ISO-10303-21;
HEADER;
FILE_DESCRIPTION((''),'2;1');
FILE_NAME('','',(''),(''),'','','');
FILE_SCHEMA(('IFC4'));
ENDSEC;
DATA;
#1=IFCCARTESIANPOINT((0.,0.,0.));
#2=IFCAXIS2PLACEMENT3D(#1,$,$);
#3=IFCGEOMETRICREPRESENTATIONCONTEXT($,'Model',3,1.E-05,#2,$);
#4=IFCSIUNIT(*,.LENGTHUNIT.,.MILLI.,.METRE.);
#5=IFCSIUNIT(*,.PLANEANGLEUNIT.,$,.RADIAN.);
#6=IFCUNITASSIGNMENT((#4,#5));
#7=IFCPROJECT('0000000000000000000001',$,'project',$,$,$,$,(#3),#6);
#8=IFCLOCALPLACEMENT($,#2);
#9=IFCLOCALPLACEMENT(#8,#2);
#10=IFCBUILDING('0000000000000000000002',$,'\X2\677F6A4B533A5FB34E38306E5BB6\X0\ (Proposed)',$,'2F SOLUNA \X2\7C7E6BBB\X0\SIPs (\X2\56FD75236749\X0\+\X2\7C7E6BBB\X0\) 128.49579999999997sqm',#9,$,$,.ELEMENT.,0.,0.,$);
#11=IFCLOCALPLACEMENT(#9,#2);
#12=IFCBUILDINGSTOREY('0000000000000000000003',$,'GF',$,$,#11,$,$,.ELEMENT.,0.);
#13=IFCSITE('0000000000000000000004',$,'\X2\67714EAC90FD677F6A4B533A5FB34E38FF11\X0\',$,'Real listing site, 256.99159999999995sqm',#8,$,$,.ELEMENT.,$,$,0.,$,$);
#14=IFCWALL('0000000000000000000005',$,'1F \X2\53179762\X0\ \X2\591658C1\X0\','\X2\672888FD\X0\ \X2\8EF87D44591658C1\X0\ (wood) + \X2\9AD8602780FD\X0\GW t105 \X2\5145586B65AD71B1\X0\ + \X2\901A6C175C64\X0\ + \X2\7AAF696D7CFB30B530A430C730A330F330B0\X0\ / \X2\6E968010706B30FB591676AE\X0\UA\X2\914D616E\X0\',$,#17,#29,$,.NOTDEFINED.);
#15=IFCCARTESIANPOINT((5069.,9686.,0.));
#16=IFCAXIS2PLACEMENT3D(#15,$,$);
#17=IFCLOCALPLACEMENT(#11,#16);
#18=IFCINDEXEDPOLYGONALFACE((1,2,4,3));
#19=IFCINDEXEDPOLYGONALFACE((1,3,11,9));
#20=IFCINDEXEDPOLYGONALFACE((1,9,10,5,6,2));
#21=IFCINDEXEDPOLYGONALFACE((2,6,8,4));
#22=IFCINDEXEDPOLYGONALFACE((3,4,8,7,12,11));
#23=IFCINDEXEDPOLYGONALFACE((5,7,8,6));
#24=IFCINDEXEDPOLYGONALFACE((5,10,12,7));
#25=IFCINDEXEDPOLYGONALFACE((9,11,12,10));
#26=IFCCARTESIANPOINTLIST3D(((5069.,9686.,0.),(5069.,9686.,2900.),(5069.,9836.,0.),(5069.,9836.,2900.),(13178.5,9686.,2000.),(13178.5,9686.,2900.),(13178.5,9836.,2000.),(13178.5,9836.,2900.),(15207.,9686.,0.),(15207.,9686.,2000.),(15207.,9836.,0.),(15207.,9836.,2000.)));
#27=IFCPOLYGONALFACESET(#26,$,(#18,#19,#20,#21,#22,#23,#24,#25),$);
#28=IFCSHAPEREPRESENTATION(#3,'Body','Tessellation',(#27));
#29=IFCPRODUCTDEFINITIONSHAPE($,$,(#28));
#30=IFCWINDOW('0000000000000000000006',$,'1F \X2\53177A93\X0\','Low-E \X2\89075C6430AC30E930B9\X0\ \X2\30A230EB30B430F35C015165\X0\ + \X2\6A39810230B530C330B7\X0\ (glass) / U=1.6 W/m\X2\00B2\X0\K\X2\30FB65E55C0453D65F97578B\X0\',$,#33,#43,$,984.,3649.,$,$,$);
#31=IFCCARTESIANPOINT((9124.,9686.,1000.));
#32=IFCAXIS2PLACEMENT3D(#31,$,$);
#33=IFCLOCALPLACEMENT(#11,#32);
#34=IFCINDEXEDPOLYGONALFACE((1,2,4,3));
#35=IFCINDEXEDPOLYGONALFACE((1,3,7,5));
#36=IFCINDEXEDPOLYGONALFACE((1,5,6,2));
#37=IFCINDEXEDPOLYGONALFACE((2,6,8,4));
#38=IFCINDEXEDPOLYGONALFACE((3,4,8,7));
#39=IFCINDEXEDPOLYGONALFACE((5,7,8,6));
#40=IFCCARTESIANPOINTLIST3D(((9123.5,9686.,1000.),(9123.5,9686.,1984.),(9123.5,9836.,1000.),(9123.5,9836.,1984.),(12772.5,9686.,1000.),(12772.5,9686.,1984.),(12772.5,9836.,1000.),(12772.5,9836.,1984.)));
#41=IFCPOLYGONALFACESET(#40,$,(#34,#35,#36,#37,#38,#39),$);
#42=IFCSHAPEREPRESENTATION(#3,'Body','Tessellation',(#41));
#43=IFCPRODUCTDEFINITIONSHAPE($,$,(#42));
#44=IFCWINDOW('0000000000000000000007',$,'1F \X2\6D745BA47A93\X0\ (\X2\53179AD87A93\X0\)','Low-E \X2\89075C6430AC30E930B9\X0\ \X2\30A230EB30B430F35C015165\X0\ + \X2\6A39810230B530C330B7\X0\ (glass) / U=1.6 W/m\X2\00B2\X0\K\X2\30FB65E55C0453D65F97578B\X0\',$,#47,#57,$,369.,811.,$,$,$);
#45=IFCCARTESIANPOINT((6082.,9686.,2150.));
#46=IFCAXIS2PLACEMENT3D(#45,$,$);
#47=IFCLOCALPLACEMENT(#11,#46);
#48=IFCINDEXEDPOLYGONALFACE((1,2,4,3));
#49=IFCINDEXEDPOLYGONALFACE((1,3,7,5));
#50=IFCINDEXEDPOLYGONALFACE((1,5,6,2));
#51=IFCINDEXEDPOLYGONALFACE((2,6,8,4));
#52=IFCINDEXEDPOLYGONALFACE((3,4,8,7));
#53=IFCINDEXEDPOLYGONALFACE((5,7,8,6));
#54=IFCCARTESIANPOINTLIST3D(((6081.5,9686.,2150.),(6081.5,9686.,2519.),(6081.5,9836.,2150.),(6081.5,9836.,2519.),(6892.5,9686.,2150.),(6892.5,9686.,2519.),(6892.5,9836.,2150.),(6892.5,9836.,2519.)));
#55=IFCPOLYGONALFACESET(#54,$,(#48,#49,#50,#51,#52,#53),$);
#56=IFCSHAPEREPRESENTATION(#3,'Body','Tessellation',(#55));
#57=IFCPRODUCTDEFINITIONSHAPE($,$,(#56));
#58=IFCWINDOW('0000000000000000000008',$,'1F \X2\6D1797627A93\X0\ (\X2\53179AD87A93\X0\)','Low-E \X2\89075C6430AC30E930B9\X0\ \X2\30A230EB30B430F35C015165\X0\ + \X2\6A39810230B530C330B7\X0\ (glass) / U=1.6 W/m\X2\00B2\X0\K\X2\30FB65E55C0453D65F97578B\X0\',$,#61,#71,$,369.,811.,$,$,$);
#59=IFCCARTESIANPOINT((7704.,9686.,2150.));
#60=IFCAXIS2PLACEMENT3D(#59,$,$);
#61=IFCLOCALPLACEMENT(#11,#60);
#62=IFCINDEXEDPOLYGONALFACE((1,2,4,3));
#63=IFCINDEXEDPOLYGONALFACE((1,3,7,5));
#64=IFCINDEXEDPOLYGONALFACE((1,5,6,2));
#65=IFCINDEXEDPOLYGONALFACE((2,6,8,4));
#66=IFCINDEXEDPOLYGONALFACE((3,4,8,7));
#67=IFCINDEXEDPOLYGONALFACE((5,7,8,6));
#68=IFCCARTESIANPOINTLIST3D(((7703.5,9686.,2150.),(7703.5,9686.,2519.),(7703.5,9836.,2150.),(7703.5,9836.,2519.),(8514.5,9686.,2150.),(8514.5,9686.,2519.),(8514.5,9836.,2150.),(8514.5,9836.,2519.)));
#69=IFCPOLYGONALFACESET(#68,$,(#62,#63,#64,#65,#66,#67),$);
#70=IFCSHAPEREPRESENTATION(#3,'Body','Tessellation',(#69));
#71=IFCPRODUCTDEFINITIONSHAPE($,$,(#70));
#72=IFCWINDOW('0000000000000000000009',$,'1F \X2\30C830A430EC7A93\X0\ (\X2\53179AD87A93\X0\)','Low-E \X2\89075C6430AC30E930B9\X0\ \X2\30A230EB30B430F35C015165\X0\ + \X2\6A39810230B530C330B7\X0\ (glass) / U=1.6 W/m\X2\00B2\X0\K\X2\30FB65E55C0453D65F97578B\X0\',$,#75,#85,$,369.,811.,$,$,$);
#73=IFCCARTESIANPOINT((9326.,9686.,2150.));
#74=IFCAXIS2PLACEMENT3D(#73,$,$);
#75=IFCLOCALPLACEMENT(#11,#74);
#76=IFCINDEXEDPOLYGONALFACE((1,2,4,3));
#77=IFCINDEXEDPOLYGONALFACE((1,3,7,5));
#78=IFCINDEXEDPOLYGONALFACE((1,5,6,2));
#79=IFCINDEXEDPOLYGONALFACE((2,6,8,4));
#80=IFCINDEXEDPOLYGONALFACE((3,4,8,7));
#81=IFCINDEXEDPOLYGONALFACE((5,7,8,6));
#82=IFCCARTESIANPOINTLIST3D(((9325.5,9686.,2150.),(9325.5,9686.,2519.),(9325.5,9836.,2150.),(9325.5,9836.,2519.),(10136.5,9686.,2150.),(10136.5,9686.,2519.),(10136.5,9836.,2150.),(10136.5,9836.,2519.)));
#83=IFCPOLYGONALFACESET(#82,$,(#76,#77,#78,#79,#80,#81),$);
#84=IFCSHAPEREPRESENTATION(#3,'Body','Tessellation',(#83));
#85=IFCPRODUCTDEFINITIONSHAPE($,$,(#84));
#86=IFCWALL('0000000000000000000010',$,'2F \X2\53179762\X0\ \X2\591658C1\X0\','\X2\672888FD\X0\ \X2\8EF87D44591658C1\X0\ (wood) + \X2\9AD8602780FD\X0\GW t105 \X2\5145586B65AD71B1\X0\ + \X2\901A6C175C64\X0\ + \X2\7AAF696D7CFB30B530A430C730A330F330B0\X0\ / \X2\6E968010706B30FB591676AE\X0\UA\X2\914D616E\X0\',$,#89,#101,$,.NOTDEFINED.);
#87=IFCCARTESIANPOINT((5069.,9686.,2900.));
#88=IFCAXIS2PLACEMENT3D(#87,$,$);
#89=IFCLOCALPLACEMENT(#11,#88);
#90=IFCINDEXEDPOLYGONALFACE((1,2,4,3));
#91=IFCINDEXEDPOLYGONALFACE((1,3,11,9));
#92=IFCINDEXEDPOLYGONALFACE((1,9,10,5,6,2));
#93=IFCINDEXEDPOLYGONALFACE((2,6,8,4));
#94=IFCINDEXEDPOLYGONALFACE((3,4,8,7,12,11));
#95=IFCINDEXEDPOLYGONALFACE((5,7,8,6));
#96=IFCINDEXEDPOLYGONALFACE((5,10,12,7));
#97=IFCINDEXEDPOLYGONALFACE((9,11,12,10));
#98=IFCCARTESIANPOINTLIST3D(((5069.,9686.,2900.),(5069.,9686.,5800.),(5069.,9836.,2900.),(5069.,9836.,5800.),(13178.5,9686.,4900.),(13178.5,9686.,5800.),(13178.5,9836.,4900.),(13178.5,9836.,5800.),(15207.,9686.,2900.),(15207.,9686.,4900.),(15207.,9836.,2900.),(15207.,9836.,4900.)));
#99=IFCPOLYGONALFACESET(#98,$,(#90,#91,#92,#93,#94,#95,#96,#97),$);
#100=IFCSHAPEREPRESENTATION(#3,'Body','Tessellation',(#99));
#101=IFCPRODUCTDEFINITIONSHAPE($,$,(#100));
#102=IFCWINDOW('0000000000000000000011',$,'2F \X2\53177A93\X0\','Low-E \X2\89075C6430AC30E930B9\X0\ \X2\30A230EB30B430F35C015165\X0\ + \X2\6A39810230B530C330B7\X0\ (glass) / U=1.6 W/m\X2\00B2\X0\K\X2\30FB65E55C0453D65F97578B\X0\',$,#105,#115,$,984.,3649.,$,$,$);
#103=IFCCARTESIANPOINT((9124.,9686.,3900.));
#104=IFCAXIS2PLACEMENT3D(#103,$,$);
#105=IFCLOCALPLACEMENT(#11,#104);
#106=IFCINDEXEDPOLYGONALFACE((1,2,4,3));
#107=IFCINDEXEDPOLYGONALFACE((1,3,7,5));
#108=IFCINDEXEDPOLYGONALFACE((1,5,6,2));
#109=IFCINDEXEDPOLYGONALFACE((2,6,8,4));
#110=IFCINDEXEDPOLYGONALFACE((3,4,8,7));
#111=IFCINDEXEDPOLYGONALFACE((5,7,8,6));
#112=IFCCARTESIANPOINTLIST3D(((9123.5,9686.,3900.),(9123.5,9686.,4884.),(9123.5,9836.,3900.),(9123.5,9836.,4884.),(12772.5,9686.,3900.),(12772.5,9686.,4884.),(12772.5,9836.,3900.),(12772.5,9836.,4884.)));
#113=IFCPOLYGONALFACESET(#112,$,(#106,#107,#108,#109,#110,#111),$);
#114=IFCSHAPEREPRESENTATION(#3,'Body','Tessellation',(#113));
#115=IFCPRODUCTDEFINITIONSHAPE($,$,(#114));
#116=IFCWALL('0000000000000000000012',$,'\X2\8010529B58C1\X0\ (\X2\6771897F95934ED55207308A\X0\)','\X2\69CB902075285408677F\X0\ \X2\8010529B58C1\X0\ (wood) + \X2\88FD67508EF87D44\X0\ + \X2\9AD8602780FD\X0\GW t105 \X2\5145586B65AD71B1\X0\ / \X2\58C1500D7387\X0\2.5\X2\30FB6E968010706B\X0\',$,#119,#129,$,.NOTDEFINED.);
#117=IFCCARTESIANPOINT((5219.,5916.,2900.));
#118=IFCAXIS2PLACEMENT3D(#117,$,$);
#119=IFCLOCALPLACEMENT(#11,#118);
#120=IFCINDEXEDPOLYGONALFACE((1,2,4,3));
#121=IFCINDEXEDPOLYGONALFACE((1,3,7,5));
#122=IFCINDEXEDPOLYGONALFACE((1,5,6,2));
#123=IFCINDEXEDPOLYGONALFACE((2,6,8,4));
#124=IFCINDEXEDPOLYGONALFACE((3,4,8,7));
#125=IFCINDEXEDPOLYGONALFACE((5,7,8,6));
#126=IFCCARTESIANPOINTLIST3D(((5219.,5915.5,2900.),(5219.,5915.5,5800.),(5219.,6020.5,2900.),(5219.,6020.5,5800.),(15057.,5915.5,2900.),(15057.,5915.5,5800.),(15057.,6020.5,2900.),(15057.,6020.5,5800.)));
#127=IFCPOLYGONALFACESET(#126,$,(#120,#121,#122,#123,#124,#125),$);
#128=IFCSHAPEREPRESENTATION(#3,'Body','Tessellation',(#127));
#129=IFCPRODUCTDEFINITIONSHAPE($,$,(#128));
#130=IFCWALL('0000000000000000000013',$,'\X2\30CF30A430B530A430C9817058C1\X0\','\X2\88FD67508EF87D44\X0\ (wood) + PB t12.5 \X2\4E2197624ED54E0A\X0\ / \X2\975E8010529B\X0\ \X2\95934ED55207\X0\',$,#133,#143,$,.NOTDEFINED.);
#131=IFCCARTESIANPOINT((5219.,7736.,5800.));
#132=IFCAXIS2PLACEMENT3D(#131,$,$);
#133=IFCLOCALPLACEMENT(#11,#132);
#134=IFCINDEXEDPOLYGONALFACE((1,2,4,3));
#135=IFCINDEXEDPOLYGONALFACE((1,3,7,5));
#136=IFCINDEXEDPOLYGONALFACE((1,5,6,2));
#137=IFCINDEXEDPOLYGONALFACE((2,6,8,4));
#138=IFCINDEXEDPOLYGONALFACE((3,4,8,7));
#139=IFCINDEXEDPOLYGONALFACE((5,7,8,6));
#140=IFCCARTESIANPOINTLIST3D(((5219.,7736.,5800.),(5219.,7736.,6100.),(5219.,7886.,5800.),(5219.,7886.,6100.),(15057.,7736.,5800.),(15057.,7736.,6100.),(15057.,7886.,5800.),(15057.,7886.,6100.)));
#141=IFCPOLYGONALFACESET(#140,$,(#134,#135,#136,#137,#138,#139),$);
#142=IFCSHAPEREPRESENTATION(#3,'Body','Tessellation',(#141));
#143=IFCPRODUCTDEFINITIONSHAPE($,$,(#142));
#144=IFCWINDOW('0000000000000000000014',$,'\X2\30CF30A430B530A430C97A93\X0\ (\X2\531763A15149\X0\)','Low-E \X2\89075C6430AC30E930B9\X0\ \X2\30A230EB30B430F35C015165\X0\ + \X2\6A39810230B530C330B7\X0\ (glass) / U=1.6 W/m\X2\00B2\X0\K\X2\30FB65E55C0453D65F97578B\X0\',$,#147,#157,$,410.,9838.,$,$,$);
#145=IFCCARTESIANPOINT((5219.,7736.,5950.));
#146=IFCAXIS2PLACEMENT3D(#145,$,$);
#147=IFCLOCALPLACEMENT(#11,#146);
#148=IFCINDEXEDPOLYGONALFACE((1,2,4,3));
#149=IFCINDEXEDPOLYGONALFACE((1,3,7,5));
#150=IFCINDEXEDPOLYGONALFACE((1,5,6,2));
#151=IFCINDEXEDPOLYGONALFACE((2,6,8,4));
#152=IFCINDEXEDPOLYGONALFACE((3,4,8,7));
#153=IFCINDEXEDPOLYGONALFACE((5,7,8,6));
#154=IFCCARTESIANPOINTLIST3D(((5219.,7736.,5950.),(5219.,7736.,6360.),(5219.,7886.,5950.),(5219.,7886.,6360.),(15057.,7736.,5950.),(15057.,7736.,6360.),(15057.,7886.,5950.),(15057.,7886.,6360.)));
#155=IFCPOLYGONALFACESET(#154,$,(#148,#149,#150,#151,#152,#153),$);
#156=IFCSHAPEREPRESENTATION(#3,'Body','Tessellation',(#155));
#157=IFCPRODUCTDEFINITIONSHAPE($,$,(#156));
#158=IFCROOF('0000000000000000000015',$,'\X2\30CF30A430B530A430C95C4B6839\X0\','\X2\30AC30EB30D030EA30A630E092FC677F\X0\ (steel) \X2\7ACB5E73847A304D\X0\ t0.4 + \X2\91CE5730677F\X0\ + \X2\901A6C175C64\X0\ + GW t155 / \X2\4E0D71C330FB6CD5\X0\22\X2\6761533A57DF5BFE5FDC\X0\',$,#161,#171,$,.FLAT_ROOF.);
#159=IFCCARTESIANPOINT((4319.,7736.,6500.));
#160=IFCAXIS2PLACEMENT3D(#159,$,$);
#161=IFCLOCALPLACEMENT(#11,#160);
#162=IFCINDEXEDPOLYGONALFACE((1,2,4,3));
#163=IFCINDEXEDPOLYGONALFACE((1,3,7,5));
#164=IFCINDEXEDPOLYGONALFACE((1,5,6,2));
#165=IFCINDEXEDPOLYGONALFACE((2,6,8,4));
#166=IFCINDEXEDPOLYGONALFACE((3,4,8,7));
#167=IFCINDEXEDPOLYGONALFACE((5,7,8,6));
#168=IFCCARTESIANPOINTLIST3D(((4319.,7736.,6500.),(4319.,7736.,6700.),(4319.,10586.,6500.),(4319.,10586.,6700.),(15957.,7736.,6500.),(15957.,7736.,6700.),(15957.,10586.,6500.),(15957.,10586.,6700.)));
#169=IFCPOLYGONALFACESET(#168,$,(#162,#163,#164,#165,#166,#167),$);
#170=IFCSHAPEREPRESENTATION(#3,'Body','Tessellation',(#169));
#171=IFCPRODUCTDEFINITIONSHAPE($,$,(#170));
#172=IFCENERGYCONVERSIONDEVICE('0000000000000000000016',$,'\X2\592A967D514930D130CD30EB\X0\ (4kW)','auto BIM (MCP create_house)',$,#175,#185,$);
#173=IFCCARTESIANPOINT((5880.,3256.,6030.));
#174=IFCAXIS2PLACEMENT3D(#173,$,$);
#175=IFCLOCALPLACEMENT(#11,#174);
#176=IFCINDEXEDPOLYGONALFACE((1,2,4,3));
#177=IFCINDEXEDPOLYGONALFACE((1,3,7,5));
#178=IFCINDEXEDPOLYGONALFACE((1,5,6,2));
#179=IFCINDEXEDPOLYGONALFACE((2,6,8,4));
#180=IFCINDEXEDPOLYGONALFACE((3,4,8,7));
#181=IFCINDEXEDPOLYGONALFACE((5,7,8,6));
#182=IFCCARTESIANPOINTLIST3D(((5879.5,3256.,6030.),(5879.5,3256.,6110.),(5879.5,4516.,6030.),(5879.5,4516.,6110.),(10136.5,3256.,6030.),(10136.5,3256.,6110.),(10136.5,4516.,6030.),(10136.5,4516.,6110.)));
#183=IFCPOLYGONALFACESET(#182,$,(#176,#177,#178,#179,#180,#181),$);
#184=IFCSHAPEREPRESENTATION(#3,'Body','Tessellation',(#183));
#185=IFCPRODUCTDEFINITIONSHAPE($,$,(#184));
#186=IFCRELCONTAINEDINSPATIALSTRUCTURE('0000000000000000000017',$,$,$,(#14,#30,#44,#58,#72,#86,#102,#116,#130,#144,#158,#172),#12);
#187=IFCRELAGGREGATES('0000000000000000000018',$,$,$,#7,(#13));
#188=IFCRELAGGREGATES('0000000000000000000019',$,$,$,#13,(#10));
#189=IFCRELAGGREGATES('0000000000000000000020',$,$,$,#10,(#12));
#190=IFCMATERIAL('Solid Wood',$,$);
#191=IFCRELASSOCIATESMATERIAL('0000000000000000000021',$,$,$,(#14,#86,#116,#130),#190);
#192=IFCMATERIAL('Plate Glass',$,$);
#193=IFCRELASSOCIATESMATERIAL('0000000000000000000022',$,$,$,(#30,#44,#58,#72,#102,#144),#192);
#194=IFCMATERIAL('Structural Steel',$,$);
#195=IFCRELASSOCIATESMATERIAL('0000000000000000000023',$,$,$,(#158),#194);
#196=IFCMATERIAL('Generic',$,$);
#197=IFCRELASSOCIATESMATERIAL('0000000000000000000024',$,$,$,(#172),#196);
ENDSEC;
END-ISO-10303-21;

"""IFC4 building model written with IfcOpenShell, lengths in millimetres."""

from ifc_helpers import new_model, si_unit, frame, frame_2d, origin, place, context, project, spatial, rectangle, extrude, material, element, fill, save


model = new_model("IFC4")

# Units and contexts
model_context = context("Model", 3, precision=1e-05, world=origin())
ifc_project = project(units=[si_unit("LENGTHUNIT", "METRE", prefix="MILLI"), si_unit("PLANEANGLEUNIT", "RADIAN")], contexts=[model_context])

# Site, building, storey
site_placement = place(None, origin())
site = spatial("IfcSite", under=ifc_project, at=site_placement, Name="東京都板橋区徳丸１", ObjectType="Real listing site, 256.99159999999995sqm", CompositionType="ELEMENT", RefElevation=0.0)
building_placement = place(site_placement, origin())
building = spatial("IfcBuilding", under=site, at=building_placement, Name="板橋区徳丸の家 (Proposed)", ObjectType="2F SOLUNA 籾殻SIPs (国産杉+籾殻) 128.49579999999997sqm", CompositionType="ELEMENT", ElevationOfRefHeight=0.0, ElevationOfTerrain=0.0)
storey_placement = place(building_placement, origin())
storey = spatial("IfcBuildingStorey", under=building, at=storey_placement, Name="GF", CompositionType="ELEMENT", Elevation=0.0)

# Wall, openings, windows
ifc_material_1 = material(Name="Solid Wood")
wall_1_placement = place(storey_placement, frame((5069.0, 9686.0, 0.0)))
wall_1 = element("IfcWall", 1, at=wall_1_placement, inside=storey, material=ifc_material_1, Name="1F 北面 外壁", Description="木製 軸組外壁 (wood) + 高性能GW t105 充填断熱 + 通気層 + 窯業系サイディング / 準耐火・外皮UA配慮", PredefinedType="NOTDEFINED", context=model_context, shape_type="SweptSolid", body=[
    extrude(rectangle(XDim=10138.0, YDim=150.0, at=frame_2d((5069.0, 75.0))), frame((5069.0, 9686.0, 0.0)), (0.0, 0.0, 1.0), 2900.0),
])
opening_1_placement = place(storey_placement, frame((9124.0, 9686.0, 1000.0)))
opening_1 = element("IfcOpeningElement", 2, at=opening_1_placement, cuts=wall_1, PredefinedType="NOTDEFINED", context=model_context, shape_type="SweptSolid", body=[
    extrude(rectangle(XDim=3649.0, YDim=150.0, at=frame_2d((1824.0, 75.0))), frame((9124.0, 9686.0, 1000.0)), (0.0, 0.0, 1.0), 984.0),
])
opening_2_placement = place(storey_placement, frame((6082.0, 9686.0, 2150.0)))
opening_2 = element("IfcOpeningElement", 3, at=opening_2_placement, cuts=wall_1, PredefinedType="NOTDEFINED", context=model_context, shape_type="SweptSolid", body=[
    extrude(rectangle(XDim=811.0, YDim=150.0, at=frame_2d((405.0, 75.0))), frame((6082.0, 9686.0, 2150.0)), (0.0, 0.0, 1.0), 369.0),
])
opening_3_placement = place(storey_placement, frame((7704.0, 9686.0, 2150.0)))
opening_3 = element("IfcOpeningElement", 4, at=opening_3_placement, cuts=wall_1, PredefinedType="NOTDEFINED", context=model_context, shape_type="SweptSolid", body=[
    extrude(rectangle(XDim=811.0, YDim=150.0, at=frame_2d((405.0, 75.0))), frame((7704.0, 9686.0, 2150.0)), (0.0, 0.0, 1.0), 369.0),
])
opening_4_placement = place(storey_placement, frame((9326.0, 9686.0, 2150.0)))
opening_4 = element("IfcOpeningElement", 5, at=opening_4_placement, cuts=wall_1, PredefinedType="NOTDEFINED", context=model_context, shape_type="SweptSolid", body=[
    extrude(rectangle(XDim=811.0, YDim=150.0, at=frame_2d((405.0, 75.0))), frame((9326.0, 9686.0, 2150.0)), (0.0, 0.0, 1.0), 369.0),
])
ifc_material_2 = material(Name="Plate Glass")
window_1_placement = place(storey_placement, frame((9124.0, 9686.0, 1000.0)))
window_1 = element("IfcWindow", 6, at=window_1_placement, inside=storey, material=ifc_material_2, Name="1F 北窓", Description="Low-E 複層ガラス アルゴン封入 + 樹脂サッシ (glass) / U=1.6 W/m²K・日射取得型", OverallHeight=984.0, OverallWidth=3649.0, context=model_context, shape_type="SweptSolid", body=[
    extrude(rectangle(XDim=3649.0, YDim=150.0, at=frame_2d((1824.0, 75.0))), frame((9124.0, 9686.0, 1000.0)), (0.0, 0.0, 1.0), 984.0),
])
fill(opening_1, window_1)
window_2_placement = place(storey_placement, frame((6082.0, 9686.0, 2150.0)))
window_2 = element("IfcWindow", 7, at=window_2_placement, inside=storey, material=ifc_material_2, Name="1F 浴室窓 (北高窓)", Description="Low-E 複層ガラス アルゴン封入 + 樹脂サッシ (glass) / U=1.6 W/m²K・日射取得型", OverallHeight=369.0, OverallWidth=811.0, context=model_context, shape_type="SweptSolid", body=[
    extrude(rectangle(XDim=811.0, YDim=150.0, at=frame_2d((405.0, 75.0))), frame((6082.0, 9686.0, 2150.0)), (0.0, 0.0, 1.0), 369.0),
])
fill(opening_2, window_2)
window_3_placement = place(storey_placement, frame((7704.0, 9686.0, 2150.0)))
window_3 = element("IfcWindow", 8, at=window_3_placement, inside=storey, material=ifc_material_2, Name="1F 洗面窓 (北高窓)", Description="Low-E 複層ガラス アルゴン封入 + 樹脂サッシ (glass) / U=1.6 W/m²K・日射取得型", OverallHeight=369.0, OverallWidth=811.0, context=model_context, shape_type="SweptSolid", body=[
    extrude(rectangle(XDim=811.0, YDim=150.0, at=frame_2d((405.0, 75.0))), frame((7704.0, 9686.0, 2150.0)), (0.0, 0.0, 1.0), 369.0),
])
fill(opening_3, window_3)
window_4_placement = place(storey_placement, frame((9326.0, 9686.0, 2150.0)))
window_4 = element("IfcWindow", 9, at=window_4_placement, inside=storey, material=ifc_material_2, Name="1F トイレ窓 (北高窓)", Description="Low-E 複層ガラス アルゴン封入 + 樹脂サッシ (glass) / U=1.6 W/m²K・日射取得型", OverallHeight=369.0, OverallWidth=811.0, context=model_context, shape_type="SweptSolid", body=[
    extrude(rectangle(XDim=811.0, YDim=150.0, at=frame_2d((405.0, 75.0))), frame((9326.0, 9686.0, 2150.0)), (0.0, 0.0, 1.0), 369.0),
])
fill(opening_4, window_4)

# Wall, opening, window
wall_2_placement = place(storey_placement, frame((5069.0, 9686.0, 2900.0)))
wall_2 = element("IfcWall", 10, at=wall_2_placement, inside=storey, material=ifc_material_1, Name="2F 北面 外壁", Description="木製 軸組外壁 (wood) + 高性能GW t105 充填断熱 + 通気層 + 窯業系サイディング / 準耐火・外皮UA配慮", PredefinedType="NOTDEFINED", context=model_context, shape_type="SweptSolid", body=[
    extrude(rectangle(XDim=10138.0, YDim=150.0, at=frame_2d((5069.0, 75.0))), frame((5069.0, 9686.0, 2900.0)), (0.0, 0.0, 1.0), 2900.0),
])
opening_5_placement = place(storey_placement, frame((9124.0, 9686.0, 3900.0)))
opening_5 = element("IfcOpeningElement", 11, at=opening_5_placement, cuts=wall_2, PredefinedType="NOTDEFINED", context=model_context, shape_type="SweptSolid", body=[
    extrude(rectangle(XDim=3649.0, YDim=150.0, at=frame_2d((1824.0, 75.0))), frame((9124.0, 9686.0, 3900.0)), (0.0, 0.0, 1.0), 984.0),
])
window_5_placement = place(storey_placement, frame((9124.0, 9686.0, 3900.0)))
window_5 = element("IfcWindow", 12, at=window_5_placement, inside=storey, material=ifc_material_2, Name="2F 北窓", Description="Low-E 複層ガラス アルゴン封入 + 樹脂サッシ (glass) / U=1.6 W/m²K・日射取得型", OverallHeight=984.0, OverallWidth=3649.0, context=model_context, shape_type="SweptSolid", body=[
    extrude(rectangle(XDim=3649.0, YDim=150.0, at=frame_2d((1824.0, 75.0))), frame((9124.0, 9686.0, 3900.0)), (0.0, 0.0, 1.0), 984.0),
])
fill(opening_5, window_5)

# Wall
wall_3_placement = place(storey_placement, frame((5219.0, 5916.0, 2900.0)))
element("IfcWall", 13, at=wall_3_placement, inside=storey, material=ifc_material_1, Name="耐力壁 (東西間仕切り)", Description="構造用合板 耐力壁 (wood) + 製材軸組 + 高性能GW t105 充填断熱 / 壁倍率2.5・準耐火", PredefinedType="NOTDEFINED", context=model_context, shape_type="SweptSolid", body=[
    extrude(rectangle(XDim=9838.0, YDim=105.0, at=frame_2d((4919.0, 52.0))), frame((5219.0, 5916.0, 2900.0)), (0.0, 0.0, 1.0), 2900.0),
])

# Wall, opening, window
wall_4_placement = place(storey_placement, frame((5219.0, 7736.0, 5800.0)))
wall_4 = element("IfcWall", 14, at=wall_4_placement, inside=storey, material=ifc_material_1, Name="ハイサイド腰壁", Description="製材軸組 (wood) + PB t12.5 両面仕上 / 非耐力 間仕切", PredefinedType="NOTDEFINED", context=model_context, shape_type="SweptSolid", body=[
    extrude(rectangle(XDim=9838.0, YDim=150.0, at=frame_2d((4919.0, 75.0))), frame((5219.0, 7736.0, 5800.0)), (0.0, 0.0, 1.0), 700.0),
])
opening_6_placement = place(storey_placement, frame((5219.0, 7736.0, 5950.0)))
opening_6 = element("IfcOpeningElement", 15, at=opening_6_placement, cuts=wall_4, PredefinedType="NOTDEFINED", context=model_context, shape_type="SweptSolid", body=[
    extrude(rectangle(XDim=9838.0, YDim=150.0, at=frame_2d((4919.0, 75.0))), frame((5219.0, 7736.0, 5950.0)), (0.0, 0.0, 1.0), 410.0),
])
window_6_placement = place(storey_placement, frame((5219.0, 7736.0, 5950.0)))
window_6 = element("IfcWindow", 16, at=window_6_placement, inside=storey, material=ifc_material_2, Name="ハイサイド窓 (北採光)", Description="Low-E 複層ガラス アルゴン封入 + 樹脂サッシ (glass) / U=1.6 W/m²K・日射取得型", OverallHeight=410.0, OverallWidth=9838.0, context=model_context, shape_type="SweptSolid", body=[
    extrude(rectangle(XDim=9838.0, YDim=150.0, at=frame_2d((4919.0, 75.0))), frame((5219.0, 7736.0, 5950.0)), (0.0, 0.0, 1.0), 410.0),
])
fill(opening_6, window_6)

# Roof
ifc_material_3 = material(Name="Structural Steel")
roof_placement = place(storey_placement, frame((4319.0, 7736.0, 6500.0)))
element("IfcRoof", 17, at=roof_placement, inside=storey, material=ifc_material_3, Name="ハイサイド屋根", Description="ガルバリウム鋼板 (steel) 立平葺き t0.4 + 野地板 + 通気層 + GW t155 / 不燃・法22条区域対応", PredefinedType="FLAT_ROOF", context=model_context, shape_type="SweptSolid", body=[
    extrude(rectangle(XDim=11638.0, YDim=2850.0, at=frame_2d((5819.0, 1425.0))), frame((4319.0, 7736.0, 6500.0)), (0.0, 0.0, 1.0), 200.0),
])

# Energy conversion device
ifc_material_4 = material(Name="Generic")
energy_conversion_device_placement = place(storey_placement, frame((5880.0, 3256.0, 6030.0)))
element("IfcEnergyConversionDevice", 18, at=energy_conversion_device_placement, inside=storey, material=ifc_material_4, Name="太陽光パネル (4kW)", Description="auto BIM (MCP create_house)", context=model_context, shape_type="SweptSolid", body=[
    extrude(rectangle(XDim=4257.0, YDim=1260.0, at=frame_2d((2128.0, 630.0))), frame((5880.0, 3256.0, 6030.0)), (0.0, 0.0, 1.0), 80.0),
])

save(model, "model.ifc")
